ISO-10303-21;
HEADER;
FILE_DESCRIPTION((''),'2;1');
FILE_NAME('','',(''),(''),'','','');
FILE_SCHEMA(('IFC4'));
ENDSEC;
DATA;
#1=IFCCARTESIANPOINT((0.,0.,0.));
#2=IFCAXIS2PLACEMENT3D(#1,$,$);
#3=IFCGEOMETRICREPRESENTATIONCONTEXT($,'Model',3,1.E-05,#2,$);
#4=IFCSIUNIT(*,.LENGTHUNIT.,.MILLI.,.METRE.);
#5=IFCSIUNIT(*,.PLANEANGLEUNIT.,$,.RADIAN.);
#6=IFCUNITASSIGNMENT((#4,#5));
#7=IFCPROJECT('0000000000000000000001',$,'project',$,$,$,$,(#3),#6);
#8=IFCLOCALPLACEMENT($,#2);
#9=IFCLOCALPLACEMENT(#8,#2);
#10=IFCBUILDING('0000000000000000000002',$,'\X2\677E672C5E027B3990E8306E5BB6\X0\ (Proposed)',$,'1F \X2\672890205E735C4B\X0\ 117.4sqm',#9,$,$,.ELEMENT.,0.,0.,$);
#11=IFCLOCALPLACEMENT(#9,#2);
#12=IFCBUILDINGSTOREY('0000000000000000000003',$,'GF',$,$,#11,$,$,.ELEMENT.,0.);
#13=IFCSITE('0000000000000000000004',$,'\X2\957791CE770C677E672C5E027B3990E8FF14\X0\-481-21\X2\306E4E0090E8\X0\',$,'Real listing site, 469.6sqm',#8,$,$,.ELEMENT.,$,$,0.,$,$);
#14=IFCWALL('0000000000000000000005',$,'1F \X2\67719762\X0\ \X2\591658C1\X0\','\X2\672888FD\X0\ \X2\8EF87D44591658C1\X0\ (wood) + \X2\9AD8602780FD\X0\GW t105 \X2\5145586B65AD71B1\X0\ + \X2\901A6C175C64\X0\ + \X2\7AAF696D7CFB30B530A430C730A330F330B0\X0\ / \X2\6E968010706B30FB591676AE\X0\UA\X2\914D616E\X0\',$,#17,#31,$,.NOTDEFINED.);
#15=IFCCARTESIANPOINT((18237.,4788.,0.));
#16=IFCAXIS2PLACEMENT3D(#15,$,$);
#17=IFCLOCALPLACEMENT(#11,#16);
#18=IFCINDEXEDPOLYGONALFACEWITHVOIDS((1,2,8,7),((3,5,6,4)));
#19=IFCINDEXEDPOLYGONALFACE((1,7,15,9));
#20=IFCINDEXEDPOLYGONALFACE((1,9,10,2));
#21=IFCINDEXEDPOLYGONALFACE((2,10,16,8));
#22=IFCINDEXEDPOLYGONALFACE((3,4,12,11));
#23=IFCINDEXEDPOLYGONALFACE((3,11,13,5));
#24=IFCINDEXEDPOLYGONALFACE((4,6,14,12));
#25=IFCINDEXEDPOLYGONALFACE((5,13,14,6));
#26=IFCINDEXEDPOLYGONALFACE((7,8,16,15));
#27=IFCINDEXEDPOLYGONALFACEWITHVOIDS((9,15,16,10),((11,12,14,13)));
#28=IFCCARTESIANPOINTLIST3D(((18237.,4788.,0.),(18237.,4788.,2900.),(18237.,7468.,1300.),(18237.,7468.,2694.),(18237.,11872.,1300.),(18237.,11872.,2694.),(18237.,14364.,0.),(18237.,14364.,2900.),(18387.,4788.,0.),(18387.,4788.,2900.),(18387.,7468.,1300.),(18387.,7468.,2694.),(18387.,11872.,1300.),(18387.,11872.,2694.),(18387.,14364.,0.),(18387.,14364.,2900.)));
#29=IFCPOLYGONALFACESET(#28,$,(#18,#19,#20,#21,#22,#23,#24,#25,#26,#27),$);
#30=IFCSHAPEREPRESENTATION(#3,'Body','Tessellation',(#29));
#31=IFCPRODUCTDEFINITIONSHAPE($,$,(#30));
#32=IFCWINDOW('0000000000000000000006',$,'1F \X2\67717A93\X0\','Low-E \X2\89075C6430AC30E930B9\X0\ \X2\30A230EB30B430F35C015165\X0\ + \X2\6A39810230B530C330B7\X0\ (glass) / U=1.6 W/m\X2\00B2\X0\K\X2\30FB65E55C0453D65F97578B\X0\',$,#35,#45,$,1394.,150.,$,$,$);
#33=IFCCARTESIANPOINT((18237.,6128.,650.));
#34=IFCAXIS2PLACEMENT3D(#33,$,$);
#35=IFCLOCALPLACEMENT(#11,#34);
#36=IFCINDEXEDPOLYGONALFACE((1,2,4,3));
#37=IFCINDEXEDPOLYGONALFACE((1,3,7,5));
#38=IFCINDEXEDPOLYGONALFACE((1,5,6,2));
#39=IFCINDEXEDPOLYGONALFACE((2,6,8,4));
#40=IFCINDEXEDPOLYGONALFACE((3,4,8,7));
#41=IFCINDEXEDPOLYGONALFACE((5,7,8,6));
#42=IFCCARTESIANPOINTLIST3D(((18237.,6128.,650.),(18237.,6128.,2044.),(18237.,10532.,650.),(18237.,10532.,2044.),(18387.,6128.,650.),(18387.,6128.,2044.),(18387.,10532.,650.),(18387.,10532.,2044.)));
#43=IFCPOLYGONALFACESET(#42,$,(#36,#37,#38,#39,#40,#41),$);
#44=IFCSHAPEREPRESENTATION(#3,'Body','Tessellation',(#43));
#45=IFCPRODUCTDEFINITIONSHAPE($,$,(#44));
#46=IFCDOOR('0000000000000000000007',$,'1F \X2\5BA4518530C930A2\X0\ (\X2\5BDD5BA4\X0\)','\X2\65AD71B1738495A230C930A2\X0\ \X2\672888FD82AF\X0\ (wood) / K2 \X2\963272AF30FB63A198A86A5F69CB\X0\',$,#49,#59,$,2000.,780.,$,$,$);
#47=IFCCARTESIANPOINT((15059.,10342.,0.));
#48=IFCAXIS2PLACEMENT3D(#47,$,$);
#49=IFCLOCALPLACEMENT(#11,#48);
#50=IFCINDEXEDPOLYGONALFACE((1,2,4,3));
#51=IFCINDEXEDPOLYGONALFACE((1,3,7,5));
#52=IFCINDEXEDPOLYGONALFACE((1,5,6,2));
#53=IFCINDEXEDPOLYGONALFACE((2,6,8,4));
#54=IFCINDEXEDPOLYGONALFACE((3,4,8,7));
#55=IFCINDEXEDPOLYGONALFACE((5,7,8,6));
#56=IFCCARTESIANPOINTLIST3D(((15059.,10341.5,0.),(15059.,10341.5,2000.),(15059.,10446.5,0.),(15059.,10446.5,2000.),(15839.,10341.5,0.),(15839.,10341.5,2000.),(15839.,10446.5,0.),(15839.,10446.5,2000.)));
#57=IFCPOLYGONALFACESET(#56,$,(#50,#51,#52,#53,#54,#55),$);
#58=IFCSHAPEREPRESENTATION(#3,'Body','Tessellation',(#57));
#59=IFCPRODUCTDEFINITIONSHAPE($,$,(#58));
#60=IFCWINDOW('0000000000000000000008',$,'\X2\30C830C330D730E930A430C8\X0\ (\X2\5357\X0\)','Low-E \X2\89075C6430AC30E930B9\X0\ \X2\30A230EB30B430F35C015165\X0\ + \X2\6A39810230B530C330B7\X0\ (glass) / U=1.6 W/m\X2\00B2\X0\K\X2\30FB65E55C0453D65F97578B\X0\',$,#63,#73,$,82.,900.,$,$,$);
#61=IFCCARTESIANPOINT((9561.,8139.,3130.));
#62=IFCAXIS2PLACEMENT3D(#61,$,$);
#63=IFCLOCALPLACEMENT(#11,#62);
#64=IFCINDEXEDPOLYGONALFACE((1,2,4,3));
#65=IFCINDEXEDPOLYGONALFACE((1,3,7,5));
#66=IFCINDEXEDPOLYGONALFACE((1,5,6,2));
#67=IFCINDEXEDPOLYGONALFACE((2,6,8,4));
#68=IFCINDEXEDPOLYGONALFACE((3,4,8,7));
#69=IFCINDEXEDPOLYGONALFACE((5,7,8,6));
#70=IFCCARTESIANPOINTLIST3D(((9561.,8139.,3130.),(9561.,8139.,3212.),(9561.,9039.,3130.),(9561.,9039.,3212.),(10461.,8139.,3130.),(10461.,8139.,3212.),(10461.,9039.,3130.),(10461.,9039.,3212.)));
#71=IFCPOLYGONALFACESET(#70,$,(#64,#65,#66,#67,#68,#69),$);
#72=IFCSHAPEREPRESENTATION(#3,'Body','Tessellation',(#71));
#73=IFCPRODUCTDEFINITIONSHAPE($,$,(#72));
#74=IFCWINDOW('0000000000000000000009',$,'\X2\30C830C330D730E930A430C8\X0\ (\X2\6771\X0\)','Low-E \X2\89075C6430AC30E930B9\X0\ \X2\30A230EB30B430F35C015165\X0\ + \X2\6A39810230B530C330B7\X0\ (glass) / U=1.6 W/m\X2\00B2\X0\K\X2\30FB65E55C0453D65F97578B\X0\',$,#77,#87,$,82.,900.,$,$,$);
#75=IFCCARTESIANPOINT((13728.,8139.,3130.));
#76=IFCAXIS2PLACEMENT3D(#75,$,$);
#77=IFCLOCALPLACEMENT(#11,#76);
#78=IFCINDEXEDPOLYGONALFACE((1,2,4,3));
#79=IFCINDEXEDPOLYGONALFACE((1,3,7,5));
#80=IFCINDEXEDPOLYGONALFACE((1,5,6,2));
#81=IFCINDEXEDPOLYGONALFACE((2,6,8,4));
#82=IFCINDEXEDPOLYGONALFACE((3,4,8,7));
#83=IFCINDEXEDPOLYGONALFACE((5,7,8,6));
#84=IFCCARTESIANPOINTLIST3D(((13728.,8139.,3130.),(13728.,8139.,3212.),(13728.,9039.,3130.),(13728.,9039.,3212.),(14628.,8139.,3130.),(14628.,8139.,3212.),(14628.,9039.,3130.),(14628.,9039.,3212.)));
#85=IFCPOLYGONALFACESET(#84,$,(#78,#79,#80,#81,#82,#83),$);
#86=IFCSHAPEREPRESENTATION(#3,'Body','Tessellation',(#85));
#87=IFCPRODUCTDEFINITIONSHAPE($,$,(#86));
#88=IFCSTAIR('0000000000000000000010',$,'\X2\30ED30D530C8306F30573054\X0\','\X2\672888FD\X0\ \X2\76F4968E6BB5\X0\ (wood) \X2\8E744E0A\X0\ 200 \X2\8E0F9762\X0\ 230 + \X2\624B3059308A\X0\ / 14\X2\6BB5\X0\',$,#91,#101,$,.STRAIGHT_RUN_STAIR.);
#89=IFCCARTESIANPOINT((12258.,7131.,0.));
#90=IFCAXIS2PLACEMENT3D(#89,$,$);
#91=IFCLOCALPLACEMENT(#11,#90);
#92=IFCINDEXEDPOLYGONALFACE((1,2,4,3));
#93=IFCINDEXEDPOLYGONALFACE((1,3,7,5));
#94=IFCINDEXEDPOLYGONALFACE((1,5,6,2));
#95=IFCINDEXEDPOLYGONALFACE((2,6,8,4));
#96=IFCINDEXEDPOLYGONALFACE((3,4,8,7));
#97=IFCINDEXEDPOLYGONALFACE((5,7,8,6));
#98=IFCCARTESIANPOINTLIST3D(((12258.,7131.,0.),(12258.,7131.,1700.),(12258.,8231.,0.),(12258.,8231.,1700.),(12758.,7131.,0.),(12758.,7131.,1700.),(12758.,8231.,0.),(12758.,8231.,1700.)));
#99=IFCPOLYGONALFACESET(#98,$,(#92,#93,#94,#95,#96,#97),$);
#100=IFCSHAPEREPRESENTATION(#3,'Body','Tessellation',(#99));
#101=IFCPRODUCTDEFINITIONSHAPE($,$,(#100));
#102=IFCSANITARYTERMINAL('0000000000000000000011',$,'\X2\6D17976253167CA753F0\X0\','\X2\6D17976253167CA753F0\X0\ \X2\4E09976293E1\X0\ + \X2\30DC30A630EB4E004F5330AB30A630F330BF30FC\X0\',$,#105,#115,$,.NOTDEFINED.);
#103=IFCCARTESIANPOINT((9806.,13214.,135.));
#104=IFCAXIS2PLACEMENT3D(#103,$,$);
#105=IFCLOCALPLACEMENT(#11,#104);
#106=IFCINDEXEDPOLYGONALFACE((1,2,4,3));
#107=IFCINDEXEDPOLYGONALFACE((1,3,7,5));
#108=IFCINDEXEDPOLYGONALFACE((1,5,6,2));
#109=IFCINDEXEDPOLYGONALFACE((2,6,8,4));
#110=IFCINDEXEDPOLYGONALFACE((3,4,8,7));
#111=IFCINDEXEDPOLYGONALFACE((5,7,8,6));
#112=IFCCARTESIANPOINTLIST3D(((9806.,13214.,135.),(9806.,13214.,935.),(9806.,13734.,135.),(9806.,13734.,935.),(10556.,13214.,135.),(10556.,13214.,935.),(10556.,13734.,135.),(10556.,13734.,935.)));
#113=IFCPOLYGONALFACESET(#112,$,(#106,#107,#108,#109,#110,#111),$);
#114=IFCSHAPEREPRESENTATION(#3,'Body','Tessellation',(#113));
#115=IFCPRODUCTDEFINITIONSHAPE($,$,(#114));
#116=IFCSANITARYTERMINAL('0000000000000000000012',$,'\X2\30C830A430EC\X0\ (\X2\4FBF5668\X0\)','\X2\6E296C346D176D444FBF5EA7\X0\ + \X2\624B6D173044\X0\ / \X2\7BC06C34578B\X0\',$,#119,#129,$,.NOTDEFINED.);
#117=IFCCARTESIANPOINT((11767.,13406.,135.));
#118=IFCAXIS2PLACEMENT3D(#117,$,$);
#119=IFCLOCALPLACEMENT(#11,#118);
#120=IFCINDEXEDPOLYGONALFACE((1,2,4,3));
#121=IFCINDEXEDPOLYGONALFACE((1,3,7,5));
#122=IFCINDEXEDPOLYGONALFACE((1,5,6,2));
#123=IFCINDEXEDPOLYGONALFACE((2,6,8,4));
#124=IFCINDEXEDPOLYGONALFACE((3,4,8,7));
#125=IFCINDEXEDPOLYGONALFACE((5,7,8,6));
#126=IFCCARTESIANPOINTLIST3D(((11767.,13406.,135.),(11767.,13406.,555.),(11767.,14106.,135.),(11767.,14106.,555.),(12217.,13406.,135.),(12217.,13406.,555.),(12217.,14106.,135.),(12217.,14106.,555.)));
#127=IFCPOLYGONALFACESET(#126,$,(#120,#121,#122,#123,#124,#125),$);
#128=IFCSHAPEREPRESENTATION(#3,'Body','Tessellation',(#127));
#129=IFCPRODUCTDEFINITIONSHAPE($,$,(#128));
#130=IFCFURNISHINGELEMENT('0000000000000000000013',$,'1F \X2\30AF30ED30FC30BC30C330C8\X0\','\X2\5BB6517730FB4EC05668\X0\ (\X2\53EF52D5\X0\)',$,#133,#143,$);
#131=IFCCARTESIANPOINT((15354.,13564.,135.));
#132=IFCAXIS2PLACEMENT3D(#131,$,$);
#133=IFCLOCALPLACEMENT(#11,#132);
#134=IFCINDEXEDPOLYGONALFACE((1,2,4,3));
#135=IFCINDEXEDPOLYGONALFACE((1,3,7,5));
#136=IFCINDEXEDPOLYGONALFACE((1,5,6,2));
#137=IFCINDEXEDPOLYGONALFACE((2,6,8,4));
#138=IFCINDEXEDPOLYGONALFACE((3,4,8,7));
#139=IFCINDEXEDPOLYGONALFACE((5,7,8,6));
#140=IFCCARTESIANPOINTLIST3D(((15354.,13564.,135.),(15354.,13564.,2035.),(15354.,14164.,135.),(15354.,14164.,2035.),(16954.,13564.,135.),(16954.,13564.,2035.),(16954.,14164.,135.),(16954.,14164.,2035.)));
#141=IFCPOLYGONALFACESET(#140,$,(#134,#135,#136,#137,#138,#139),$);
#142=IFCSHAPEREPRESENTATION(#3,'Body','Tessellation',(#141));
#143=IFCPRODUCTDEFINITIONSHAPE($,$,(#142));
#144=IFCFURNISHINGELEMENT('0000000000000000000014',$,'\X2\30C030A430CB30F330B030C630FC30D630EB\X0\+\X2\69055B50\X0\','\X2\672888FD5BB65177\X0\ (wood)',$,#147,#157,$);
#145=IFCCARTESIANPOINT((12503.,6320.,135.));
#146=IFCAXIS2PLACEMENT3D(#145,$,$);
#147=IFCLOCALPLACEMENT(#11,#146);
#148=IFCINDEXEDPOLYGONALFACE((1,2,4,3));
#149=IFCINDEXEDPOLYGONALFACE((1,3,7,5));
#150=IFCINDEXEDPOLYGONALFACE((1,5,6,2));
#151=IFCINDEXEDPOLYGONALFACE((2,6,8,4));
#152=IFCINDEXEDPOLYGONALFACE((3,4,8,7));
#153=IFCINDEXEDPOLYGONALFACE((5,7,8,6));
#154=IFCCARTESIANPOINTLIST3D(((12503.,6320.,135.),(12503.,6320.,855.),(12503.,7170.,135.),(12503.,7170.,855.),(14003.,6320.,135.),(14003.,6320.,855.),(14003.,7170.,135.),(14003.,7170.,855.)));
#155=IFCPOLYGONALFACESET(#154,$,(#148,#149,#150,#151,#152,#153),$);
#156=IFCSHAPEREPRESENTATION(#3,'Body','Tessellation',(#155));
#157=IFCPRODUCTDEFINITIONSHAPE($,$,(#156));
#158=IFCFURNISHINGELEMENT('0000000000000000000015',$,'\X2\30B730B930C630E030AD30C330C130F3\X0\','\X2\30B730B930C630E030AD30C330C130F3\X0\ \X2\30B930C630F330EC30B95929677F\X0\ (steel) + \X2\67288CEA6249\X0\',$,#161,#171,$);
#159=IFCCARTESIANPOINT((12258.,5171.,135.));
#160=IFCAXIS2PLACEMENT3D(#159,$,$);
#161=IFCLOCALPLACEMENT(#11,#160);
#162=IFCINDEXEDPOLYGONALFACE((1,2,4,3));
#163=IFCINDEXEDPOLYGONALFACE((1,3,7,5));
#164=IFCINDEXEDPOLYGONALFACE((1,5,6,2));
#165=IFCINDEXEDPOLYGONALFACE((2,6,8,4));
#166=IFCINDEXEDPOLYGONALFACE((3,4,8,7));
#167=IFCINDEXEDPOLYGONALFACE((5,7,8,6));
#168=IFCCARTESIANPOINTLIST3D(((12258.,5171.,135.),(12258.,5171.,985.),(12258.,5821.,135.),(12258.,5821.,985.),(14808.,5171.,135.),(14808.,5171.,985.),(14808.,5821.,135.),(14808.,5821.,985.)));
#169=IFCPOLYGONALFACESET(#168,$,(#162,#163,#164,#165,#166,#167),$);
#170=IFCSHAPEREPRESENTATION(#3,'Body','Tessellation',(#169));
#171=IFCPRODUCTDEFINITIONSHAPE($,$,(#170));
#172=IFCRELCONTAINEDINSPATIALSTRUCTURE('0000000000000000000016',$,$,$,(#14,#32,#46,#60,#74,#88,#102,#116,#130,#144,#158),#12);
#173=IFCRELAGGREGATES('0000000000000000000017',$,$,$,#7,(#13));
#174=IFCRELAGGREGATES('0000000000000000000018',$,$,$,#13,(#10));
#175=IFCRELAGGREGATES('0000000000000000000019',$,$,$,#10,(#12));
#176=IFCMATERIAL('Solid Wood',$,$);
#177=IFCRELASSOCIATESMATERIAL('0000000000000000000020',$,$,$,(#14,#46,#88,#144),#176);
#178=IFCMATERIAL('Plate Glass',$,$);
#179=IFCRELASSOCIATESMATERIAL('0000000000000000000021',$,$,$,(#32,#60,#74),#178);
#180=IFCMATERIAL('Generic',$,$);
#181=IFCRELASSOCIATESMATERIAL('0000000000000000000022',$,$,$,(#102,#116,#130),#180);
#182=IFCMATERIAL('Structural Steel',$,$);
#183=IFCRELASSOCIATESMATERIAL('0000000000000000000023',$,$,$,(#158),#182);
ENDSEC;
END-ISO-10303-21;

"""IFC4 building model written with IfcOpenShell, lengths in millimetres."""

from ifc_helpers import new_model, si_unit, frame, frame_2d, origin, place, context, project, spatial, rectangle, extrude, material, element, fill, save


model = new_model("IFC4")

# Units and contexts
model_context = context("Model", 3, precision=1e-05, world=origin())
ifc_project = project(units=[si_unit("LENGTHUNIT", "METRE", prefix="MILLI"), si_unit("PLANEANGLEUNIT", "RADIAN")], contexts=[model_context])

# Site, building, storey
site_placement = place(None, origin())
site = spatial("IfcSite", under=ifc_project, at=site_placement, Name="長野県松本市笹部４-481-21の一部", ObjectType="Real listing site, 469.6sqm", CompositionType="ELEMENT", RefElevation=0.0)
building_placement = place(site_placement, origin())
building = spatial("IfcBuilding", under=site, at=building_placement, Name="松本市笹部の家 (Proposed)", ObjectType="1F 木造平屋 117.4sqm", CompositionType="ELEMENT", ElevationOfRefHeight=0.0, ElevationOfTerrain=0.0)
storey_placement = place(building_placement, origin())
storey = spatial("IfcBuildingStorey", under=building, at=storey_placement, Name="GF", CompositionType="ELEMENT", Elevation=0.0)

# Wall, opening, window
ifc_material_1 = material(Name="Solid Wood")
wall_1_placement = place(storey_placement, frame((18237.0, 4788.0, 0.0)))
wall_1 = element("IfcWall", 1, at=wall_1_placement, inside=storey, material=ifc_material_1, Name="1F 東面 外壁", Description="木製 軸組外壁 (wood) + 高性能GW t105 充填断熱 + 通気層 + 窯業系サイディング / 準耐火・外皮UA配慮", PredefinedType="NOTDEFINED", context=model_context, shape_type="SweptSolid", body=[
    extrude(rectangle(XDim=150.0, YDim=9576.0, at=frame_2d((75.0, 4788.0))), frame((18237.0, 4788.0, 0.0)), (0.0, 0.0, 1.0), 2900.0),
])
opening_placement = place(storey_placement, frame((18237.0, 6128.0, 650.0)))
opening = element("IfcOpeningElement", 2, at=opening_placement, cuts=wall_1, PredefinedType="NOTDEFINED", context=model_context, shape_type="SweptSolid", body=[
    extrude(rectangle(XDim=150.0, YDim=4404.0, at=frame_2d((75.0, 2202.0))), frame((18237.0, 6128.0, 650.0)), (0.0, 0.0, 1.0), 1394.0),
])
ifc_material_2 = material(Name="Plate Glass")
window_1_placement = place(storey_placement, frame((18237.0, 6128.0, 650.0)))
window_1 = element("IfcWindow", 3, at=window_1_placement, inside=storey, material=ifc_material_2, Name="1F 東窓", Description="Low-E 複層ガラス アルゴン封入 + 樹脂サッシ (glass) / U=1.6 W/m²K・日射取得型", OverallHeight=1394.0, OverallWidth=150.0, context=model_context, shape_type="SweptSolid", body=[
    extrude(rectangle(XDim=150.0, YDim=4404.0, at=frame_2d((75.0, 2202.0))), frame((18237.0, 6128.0, 650.0)), (0.0, 0.0, 1.0), 1394.0),
])
fill(opening, window_1)

# Door
door_placement = place(storey_placement, frame((15059.0, 10342.0, 0.0)))
element("IfcDoor", 4, at=door_placement, inside=storey, material=ifc_material_1, Name="1F 室内ドア (寝室)", Description="断熱玄関ドア 木製芯 (wood) / K2 防犯・採風機構", OverallHeight=2000.0, OverallWidth=780.0, context=model_context, shape_type="SweptSolid", body=[
    extrude(rectangle(XDim=780.0, YDim=105.0, at=frame_2d((390.0, 52.0))), frame((15059.0, 10342.0, 0.0)), (0.0, 0.0, 1.0), 2000.0),
])

# Windows
window_2_placement = place(storey_placement, frame((9561.0, 8139.0, 3130.0)))
element("IfcWindow", 5, at=window_2_placement, inside=storey, material=ifc_material_2, Name="トップライト (南)", Description="Low-E 複層ガラス アルゴン封入 + 樹脂サッシ (glass) / U=1.6 W/m²K・日射取得型", OverallHeight=82.0, OverallWidth=900.0, context=model_context, shape_type="SweptSolid", body=[
    extrude(rectangle(XDim=900.0, YDim=900.0, at=frame_2d((450.0, 450.0))), frame((9561.0, 8139.0, 3130.0)), (0.0, 0.0, 1.0), 82.0),
])
window_3_placement = place(storey_placement, frame((13728.0, 8139.0, 3130.0)))
element("IfcWindow", 6, at=window_3_placement, inside=storey, material=ifc_material_2, Name="トップライト (東)", Description="Low-E 複層ガラス アルゴン封入 + 樹脂サッシ (glass) / U=1.6 W/m²K・日射取得型", OverallHeight=82.0, OverallWidth=900.0, context=model_context, shape_type="SweptSolid", body=[
    extrude(rectangle(XDim=900.0, YDim=900.0, at=frame_2d((450.0, 450.0))), frame((13728.0, 8139.0, 3130.0)), (0.0, 0.0, 1.0), 82.0),
])

# Stair
stair_placement = place(storey_placement, frame((12258.0, 7131.0, 0.0)))
element("IfcStair", 7, at=stair_placement, inside=storey, material=ifc_material_1, Name="ロフトはしご", Description="木製 直階段 (wood) 蹴上 200 踏面 230 + 手すり / 14段", PredefinedType="STRAIGHT_RUN_STAIR", context=model_context, shape_type="SweptSolid", body=[
    extrude(rectangle(XDim=500.0, YDim=1100.0, at=frame_2d((250.0, 550.0))), frame((12258.0, 7131.0, 0.0)), (0.0, 0.0, 1.0), 1700.0),
])

# Sanitary terminals
ifc_material_3 = material(Name="Generic")
sanitary_terminal_1_placement = place(storey_placement, frame((9806.0, 13214.0, 135.0)))
element("IfcSanitaryTerminal", 8, at=sanitary_terminal_1_placement, inside=storey, material=ifc_material_3, Name="洗面化粧台", Description="洗面化粧台 三面鏡 + ボウル一体カウンター", PredefinedType="NOTDEFINED", context=model_context, shape_type="SweptSolid", body=[
    extrude(rectangle(XDim=750.0, YDim=520.0, at=frame_2d((375.0, 260.0))), frame((9806.0, 13214.0, 135.0)), (0.0, 0.0, 1.0), 800.0),
])
sanitary_terminal_2_placement = place(storey_placement, frame((11767.0, 13406.0, 135.0)))
element("IfcSanitaryTerminal", 9, at=sanitary_terminal_2_placement, inside=storey, material=ifc_material_3, Name="トイレ (便器)", Description="温水洗浄便座 + 手洗い / 節水型", PredefinedType="NOTDEFINED", context=model_context, shape_type="SweptSolid", body=[
    extrude(rectangle(XDim=450.0, YDim=700.0, at=frame_2d((225.0, 350.0))), frame((11767.0, 13406.0, 135.0)), (0.0, 0.0, 1.0), 420.0),
])

# Furnishing elements
furnishing_1_placement = place(storey_placement, frame((15354.0, 13564.0, 135.0)))
element("IfcFurnishingElement", 10, at=furnishing_1_placement, inside=storey, material=ifc_material_3, Name="1F クローゼット", Description="家具・什器 (可動)", context=model_context, shape_type="SweptSolid", body=[
    extrude(rectangle(XDim=1600.0, YDim=600.0, at=frame_2d((800.0, 300.0))), frame((15354.0, 13564.0, 135.0)), (0.0, 0.0, 1.0), 1900.0),
])
furnishing_2_placement = place(storey_placement, frame((12503.0, 6320.0, 135.0)))
element("IfcFurnishingElement", 11, at=furnishing_2_placement, inside=storey, material=ifc_material_1, Name="ダイニングテーブル+椅子", Description="木製家具 (wood)", context=model_context, shape_type="SweptSolid", body=[
    extrude(rectangle(XDim=1500.0, YDim=850.0, at=frame_2d((750.0, 425.0))), frame((12503.0, 6320.0, 135.0)), (0.0, 0.0, 1.0), 720.0),
])
ifc_material_4 = material(Name="Structural Steel")
furnishing_3_placement = place(storey_placement, frame((12258.0, 5171.0, 135.0)))
element("IfcFurnishingElement", 12, at=furnishing_3_placement, inside=storey, material=ifc_material_4, Name="システムキッチン", Description="システムキッチン ステンレス天板 (steel) + 木質扉", context=model_context, shape_type="SweptSolid", body=[
    extrude(rectangle(XDim=2550.0, YDim=650.0, at=frame_2d((1275.0, 325.0))), frame((12258.0, 5171.0, 135.0)), (0.0, 0.0, 1.0), 850.0),
])

save(model, "model.ifc")
